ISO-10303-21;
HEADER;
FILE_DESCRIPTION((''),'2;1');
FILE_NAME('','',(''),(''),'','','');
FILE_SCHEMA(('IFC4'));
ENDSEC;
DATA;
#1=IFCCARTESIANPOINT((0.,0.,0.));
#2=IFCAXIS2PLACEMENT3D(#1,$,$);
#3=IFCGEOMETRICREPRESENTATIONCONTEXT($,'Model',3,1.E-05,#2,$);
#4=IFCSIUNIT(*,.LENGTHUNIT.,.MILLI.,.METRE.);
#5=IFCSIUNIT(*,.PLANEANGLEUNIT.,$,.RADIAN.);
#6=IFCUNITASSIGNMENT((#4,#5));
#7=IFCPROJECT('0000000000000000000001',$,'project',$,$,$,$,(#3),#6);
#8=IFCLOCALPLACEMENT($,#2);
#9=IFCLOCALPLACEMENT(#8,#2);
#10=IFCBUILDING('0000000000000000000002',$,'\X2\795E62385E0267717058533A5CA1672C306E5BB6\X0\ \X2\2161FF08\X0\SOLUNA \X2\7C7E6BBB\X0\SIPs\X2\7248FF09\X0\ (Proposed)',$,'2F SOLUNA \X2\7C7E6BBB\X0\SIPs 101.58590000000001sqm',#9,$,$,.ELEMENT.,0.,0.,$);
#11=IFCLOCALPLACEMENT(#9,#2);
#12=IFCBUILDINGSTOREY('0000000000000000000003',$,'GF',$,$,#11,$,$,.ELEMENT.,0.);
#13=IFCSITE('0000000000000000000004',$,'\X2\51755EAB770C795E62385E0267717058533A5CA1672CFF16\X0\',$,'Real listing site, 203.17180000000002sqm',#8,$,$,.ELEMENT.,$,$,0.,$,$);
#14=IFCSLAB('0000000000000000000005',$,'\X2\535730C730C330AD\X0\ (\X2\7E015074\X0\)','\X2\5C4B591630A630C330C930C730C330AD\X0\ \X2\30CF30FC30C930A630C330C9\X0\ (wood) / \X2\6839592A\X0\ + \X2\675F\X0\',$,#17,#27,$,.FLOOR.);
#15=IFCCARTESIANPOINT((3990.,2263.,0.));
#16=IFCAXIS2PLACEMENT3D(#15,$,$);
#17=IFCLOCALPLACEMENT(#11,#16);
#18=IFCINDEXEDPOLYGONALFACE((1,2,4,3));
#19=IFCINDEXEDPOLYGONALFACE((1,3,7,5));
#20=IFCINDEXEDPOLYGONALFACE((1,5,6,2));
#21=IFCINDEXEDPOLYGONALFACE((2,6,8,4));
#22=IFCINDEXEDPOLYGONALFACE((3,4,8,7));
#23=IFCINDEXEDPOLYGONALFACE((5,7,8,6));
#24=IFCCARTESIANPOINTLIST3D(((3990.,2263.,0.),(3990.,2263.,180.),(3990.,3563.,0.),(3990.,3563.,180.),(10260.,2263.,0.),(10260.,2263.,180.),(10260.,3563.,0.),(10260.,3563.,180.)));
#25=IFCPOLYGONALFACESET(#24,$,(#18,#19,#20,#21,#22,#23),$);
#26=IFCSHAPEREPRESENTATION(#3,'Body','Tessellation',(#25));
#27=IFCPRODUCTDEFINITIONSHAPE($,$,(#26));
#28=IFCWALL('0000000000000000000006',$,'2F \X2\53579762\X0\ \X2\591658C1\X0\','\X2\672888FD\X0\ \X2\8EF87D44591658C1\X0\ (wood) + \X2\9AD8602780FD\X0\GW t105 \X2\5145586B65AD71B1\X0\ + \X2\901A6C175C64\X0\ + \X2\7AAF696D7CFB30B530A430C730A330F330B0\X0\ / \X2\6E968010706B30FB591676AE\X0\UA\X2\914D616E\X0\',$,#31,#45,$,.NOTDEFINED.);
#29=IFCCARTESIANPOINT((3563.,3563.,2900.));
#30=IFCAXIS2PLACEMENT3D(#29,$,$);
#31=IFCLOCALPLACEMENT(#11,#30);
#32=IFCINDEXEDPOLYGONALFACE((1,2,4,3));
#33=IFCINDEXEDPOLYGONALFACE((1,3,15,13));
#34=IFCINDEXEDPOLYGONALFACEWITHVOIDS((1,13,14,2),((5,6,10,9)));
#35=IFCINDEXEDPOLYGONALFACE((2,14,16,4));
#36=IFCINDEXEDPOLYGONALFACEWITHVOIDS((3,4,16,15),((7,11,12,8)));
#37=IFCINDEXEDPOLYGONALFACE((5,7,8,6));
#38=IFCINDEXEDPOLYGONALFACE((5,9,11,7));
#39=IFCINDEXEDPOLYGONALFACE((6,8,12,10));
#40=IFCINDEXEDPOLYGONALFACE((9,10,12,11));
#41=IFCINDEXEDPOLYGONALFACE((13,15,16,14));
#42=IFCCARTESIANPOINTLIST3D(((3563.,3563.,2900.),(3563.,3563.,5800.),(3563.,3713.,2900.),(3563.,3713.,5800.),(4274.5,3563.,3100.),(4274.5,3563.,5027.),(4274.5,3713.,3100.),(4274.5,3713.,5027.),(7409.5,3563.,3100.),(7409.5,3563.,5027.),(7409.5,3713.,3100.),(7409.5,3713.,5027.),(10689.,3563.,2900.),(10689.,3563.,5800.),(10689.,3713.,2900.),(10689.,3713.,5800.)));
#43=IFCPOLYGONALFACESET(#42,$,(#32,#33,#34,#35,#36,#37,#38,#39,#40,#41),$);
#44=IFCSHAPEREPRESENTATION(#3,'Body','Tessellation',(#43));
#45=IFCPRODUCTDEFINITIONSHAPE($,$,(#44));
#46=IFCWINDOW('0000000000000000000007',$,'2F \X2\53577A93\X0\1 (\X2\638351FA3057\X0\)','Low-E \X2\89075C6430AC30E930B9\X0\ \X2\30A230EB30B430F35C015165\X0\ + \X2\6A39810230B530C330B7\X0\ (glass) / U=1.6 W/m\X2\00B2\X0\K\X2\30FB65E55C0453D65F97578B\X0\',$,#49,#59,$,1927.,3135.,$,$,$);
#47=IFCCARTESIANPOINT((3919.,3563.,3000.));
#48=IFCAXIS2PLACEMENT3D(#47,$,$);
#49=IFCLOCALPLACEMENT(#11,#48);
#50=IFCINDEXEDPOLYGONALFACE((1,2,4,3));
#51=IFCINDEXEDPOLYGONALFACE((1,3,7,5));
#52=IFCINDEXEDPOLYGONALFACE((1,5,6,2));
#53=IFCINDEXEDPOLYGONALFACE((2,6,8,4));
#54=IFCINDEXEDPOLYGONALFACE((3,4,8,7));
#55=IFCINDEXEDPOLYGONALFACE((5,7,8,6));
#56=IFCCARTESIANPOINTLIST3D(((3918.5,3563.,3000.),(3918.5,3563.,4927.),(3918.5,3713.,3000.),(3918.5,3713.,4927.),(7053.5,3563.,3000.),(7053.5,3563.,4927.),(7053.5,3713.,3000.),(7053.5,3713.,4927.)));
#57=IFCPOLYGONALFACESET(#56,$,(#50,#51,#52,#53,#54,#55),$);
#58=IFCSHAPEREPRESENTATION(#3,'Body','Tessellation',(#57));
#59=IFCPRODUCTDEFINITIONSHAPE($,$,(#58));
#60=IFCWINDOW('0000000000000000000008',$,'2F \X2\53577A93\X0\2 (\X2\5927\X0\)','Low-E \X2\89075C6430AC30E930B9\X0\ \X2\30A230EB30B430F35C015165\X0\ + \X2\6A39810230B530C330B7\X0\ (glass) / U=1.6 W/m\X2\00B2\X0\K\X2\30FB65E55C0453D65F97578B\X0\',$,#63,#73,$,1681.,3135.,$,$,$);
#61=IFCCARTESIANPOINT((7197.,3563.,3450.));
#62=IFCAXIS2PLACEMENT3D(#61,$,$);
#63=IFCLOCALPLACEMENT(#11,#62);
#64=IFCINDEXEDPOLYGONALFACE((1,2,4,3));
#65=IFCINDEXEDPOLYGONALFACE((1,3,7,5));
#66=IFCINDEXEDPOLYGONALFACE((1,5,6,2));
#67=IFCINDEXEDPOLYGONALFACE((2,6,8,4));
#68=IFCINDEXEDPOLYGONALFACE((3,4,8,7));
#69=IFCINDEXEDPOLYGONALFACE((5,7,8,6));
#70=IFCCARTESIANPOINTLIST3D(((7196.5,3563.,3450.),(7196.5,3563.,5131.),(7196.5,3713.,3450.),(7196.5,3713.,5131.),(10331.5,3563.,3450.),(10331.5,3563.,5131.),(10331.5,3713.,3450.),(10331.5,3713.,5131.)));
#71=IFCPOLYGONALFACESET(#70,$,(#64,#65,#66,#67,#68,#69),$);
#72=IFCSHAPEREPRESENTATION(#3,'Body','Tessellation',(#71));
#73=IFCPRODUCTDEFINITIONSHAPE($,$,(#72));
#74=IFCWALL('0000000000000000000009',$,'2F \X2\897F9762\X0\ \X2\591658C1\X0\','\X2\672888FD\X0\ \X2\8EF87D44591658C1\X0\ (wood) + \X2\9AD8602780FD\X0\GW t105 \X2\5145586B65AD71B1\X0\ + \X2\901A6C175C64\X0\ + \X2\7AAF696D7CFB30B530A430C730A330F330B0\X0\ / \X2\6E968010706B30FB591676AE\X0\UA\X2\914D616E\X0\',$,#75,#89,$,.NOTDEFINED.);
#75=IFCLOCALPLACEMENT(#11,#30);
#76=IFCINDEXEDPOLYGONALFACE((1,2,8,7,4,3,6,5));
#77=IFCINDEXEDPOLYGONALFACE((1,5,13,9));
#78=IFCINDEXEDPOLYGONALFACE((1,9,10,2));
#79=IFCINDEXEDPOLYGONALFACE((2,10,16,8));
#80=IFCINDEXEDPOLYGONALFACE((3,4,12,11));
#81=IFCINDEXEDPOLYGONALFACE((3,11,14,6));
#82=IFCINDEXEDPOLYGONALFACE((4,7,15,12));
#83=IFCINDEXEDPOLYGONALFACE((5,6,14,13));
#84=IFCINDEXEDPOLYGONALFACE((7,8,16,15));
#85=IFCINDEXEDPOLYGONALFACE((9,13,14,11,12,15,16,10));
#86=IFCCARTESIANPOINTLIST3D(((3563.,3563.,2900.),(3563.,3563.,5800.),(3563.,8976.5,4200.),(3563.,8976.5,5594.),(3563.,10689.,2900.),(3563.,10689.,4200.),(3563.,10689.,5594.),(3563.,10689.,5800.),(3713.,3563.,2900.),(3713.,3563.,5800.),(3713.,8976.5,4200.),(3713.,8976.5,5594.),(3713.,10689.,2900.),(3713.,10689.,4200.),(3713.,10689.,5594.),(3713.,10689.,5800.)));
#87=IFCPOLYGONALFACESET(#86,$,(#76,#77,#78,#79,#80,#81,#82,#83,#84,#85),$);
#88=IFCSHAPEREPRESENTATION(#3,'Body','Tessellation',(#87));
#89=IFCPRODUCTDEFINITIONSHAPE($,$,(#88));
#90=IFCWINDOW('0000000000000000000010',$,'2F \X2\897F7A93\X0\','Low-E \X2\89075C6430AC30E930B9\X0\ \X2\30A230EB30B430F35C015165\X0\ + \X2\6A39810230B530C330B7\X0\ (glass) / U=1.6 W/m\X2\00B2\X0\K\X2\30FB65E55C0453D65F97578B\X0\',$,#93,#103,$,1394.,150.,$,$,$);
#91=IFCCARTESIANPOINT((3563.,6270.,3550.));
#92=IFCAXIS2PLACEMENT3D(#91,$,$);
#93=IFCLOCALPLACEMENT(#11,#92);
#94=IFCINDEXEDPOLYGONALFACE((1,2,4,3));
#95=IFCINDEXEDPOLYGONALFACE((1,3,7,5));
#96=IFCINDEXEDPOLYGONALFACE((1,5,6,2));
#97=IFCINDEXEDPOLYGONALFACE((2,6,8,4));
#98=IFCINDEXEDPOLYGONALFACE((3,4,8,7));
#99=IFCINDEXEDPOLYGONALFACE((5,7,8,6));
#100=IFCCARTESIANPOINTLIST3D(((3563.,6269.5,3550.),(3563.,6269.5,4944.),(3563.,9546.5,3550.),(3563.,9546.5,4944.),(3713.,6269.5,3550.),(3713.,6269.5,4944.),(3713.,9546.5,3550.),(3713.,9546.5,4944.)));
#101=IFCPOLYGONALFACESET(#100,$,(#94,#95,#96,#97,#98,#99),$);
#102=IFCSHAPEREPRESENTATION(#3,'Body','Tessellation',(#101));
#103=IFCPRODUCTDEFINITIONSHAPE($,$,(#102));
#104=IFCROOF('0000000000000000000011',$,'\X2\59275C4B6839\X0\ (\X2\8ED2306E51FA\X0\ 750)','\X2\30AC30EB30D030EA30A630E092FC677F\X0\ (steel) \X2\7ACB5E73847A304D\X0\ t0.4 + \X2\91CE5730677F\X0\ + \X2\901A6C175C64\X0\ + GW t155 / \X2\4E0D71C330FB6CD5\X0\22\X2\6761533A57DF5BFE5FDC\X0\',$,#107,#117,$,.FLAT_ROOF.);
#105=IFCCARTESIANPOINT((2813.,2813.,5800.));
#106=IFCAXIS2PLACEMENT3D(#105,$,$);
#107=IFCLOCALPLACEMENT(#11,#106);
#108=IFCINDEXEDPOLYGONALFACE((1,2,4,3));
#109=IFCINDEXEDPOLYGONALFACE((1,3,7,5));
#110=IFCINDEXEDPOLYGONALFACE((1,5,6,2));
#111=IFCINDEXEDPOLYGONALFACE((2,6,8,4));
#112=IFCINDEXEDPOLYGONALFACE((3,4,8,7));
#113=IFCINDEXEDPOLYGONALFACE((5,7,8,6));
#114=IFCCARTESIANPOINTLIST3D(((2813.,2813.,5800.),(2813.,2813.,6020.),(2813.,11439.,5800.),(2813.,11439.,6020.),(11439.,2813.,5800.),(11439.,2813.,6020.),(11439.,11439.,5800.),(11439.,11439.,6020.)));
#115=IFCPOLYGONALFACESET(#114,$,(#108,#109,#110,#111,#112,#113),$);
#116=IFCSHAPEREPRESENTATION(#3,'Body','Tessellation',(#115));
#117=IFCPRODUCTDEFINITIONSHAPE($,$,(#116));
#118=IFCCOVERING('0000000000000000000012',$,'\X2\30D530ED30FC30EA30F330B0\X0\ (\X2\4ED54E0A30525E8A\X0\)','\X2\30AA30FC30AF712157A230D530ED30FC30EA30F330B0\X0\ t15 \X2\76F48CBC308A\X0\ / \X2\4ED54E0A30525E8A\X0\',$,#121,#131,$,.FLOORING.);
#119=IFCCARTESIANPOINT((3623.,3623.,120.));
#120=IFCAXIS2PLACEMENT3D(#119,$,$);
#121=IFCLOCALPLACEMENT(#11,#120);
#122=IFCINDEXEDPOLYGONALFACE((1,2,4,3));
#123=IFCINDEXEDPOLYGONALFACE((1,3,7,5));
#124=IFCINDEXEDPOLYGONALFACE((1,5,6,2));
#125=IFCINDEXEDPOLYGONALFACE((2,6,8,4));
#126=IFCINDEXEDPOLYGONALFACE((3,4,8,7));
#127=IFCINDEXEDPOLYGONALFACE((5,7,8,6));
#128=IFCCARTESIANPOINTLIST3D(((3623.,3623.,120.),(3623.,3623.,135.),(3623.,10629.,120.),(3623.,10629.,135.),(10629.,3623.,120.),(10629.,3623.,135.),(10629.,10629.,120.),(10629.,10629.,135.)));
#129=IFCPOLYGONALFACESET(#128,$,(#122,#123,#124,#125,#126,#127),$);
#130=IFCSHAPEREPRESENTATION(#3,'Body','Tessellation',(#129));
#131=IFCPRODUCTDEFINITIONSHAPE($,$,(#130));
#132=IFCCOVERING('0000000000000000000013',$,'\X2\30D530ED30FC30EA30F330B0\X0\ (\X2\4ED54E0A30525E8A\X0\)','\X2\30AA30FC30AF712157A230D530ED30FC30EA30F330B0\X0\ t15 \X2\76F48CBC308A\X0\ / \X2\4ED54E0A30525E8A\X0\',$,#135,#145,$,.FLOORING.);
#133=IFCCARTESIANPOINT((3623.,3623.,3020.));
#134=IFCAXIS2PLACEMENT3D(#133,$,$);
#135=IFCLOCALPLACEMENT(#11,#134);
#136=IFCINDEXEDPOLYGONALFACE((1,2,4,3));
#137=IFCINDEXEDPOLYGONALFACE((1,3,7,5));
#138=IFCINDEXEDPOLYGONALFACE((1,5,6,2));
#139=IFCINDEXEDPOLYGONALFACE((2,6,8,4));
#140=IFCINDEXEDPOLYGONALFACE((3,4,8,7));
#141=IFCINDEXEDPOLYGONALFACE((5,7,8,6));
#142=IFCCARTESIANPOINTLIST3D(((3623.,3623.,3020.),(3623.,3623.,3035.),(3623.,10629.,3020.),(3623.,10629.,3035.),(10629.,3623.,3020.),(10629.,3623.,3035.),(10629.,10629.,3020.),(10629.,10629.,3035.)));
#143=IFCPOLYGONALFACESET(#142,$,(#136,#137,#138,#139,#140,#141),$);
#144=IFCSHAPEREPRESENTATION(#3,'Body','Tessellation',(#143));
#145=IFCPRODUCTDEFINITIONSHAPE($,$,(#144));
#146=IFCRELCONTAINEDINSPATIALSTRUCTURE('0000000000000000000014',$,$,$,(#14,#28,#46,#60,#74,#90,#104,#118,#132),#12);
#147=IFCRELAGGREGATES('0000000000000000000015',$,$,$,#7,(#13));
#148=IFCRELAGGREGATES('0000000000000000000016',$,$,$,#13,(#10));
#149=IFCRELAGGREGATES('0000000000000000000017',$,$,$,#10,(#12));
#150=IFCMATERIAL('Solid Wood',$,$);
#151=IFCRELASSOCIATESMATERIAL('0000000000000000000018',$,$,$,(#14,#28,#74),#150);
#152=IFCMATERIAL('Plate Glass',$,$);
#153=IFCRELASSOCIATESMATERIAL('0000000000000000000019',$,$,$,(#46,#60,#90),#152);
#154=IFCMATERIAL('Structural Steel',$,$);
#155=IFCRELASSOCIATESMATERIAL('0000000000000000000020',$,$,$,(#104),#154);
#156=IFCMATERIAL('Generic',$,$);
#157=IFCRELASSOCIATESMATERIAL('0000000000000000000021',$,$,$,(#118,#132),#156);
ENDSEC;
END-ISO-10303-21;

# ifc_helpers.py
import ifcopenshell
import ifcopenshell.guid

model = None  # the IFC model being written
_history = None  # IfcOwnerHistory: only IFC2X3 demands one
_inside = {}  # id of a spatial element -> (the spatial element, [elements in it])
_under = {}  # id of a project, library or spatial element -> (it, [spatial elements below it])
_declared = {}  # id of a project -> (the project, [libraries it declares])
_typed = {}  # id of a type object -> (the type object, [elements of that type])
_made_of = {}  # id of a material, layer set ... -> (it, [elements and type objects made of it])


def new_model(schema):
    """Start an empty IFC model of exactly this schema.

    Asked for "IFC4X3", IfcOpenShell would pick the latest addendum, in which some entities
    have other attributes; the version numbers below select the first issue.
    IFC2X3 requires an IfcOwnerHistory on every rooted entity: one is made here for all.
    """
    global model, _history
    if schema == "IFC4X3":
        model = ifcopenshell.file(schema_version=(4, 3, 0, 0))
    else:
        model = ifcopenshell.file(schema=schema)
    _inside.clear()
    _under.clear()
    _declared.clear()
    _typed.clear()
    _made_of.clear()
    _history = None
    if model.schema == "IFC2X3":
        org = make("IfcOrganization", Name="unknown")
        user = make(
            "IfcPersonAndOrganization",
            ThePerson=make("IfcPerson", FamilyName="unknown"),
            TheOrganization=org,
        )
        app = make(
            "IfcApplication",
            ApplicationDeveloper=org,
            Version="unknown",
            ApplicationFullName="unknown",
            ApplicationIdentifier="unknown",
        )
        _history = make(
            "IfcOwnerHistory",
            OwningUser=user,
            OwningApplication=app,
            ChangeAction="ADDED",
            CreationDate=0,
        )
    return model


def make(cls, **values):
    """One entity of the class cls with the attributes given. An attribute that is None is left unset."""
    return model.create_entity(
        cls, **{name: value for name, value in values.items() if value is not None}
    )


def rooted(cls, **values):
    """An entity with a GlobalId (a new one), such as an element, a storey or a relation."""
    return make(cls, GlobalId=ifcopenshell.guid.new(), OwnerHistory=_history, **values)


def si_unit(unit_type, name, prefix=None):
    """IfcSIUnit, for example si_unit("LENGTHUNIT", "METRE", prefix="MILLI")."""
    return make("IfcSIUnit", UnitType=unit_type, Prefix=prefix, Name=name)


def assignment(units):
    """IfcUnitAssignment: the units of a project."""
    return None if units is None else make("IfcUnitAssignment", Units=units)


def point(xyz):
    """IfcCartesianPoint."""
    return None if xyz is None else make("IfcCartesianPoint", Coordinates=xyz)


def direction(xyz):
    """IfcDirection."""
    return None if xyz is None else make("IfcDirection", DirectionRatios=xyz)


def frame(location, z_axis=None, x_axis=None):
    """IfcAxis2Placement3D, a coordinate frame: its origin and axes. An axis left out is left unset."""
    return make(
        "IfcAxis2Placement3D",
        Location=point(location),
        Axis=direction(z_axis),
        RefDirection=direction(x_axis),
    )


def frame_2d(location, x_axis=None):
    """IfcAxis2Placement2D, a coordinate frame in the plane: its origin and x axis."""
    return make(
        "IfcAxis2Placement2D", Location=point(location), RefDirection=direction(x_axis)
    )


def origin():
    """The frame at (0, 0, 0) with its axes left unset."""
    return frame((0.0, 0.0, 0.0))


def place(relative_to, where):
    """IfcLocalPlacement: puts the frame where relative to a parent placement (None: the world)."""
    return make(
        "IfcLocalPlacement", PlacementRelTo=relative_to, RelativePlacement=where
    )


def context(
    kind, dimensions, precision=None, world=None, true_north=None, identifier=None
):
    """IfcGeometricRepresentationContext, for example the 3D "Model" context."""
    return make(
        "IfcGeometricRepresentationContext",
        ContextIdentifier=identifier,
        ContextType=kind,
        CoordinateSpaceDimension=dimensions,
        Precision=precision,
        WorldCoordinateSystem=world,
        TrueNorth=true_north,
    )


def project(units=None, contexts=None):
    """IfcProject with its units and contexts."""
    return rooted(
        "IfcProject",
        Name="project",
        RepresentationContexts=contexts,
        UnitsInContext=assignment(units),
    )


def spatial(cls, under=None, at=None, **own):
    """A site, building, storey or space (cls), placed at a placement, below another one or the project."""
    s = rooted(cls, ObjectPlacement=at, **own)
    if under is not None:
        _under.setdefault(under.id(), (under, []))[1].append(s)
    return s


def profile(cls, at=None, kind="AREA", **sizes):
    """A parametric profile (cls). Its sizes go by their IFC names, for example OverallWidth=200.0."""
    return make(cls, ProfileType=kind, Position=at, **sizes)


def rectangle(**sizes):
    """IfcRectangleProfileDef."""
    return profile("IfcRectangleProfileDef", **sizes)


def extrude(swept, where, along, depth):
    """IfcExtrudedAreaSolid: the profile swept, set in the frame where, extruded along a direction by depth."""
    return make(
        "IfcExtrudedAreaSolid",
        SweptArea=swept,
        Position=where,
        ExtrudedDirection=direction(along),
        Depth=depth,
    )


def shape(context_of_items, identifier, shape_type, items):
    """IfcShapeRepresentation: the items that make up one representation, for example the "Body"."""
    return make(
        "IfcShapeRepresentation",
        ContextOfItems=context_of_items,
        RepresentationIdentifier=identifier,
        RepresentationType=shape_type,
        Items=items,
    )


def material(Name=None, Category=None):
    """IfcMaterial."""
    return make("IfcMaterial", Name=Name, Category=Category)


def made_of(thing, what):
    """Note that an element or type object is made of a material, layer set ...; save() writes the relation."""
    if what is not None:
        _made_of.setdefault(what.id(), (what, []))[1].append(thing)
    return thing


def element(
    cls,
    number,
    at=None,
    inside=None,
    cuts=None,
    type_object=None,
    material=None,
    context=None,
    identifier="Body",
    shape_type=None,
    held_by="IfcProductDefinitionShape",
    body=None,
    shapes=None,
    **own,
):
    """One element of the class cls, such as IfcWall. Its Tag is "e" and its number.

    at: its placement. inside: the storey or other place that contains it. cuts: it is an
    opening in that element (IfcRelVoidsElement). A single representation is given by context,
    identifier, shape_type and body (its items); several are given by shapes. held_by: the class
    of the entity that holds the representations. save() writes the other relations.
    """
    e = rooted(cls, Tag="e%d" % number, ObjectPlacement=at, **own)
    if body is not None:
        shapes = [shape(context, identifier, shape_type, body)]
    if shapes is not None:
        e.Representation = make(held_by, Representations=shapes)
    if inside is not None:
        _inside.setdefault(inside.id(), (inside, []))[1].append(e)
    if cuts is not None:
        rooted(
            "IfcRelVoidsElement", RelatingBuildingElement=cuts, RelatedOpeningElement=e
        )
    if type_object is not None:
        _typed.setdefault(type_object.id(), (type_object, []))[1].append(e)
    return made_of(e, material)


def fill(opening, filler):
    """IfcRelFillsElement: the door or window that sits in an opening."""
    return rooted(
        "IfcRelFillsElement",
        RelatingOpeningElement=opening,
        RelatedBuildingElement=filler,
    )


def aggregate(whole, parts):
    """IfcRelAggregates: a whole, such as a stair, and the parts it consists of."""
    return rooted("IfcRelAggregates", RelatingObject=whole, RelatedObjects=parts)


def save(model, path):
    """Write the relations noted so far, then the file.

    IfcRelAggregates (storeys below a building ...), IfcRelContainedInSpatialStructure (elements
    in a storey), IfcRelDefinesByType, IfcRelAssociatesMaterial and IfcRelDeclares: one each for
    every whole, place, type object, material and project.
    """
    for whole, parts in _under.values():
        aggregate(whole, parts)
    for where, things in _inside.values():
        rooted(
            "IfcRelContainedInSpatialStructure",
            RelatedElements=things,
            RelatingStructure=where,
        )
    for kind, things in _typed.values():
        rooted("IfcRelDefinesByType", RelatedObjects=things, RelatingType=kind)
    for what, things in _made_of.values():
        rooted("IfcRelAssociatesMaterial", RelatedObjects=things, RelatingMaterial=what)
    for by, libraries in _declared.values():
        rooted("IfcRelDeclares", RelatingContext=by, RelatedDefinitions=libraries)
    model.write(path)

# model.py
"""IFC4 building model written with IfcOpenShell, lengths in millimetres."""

from ifc_helpers import new_model, si_unit, frame, frame_2d, origin, place, context, project, spatial, rectangle, extrude, material, element, fill, save


model = new_model("IFC4")

# Units and contexts
model_context = context("Model", 3, precision=1e-05, world=origin())
ifc_project = project(units=[si_unit("LENGTHUNIT", "METRE", prefix="MILLI"), si_unit("PLANEANGLEUNIT", "RADIAN")], contexts=[model_context])

# Site, building, storey
site_placement = place(None, origin())
site = spatial("IfcSite", under=ifc_project, at=site_placement, Name="兵庫県神戸市東灘区岡本６", ObjectType="Real listing site, 203.17180000000002sqm", CompositionType="ELEMENT", RefElevation=0.0)
building_placement = place(site_placement, origin())
building = spatial("IfcBuilding", under=site, at=building_placement, Name="神戸市東灘区岡本の家 Ⅱ（SOLUNA 籾殻SIPs版） (Proposed)", ObjectType="2F SOLUNA 籾殻SIPs 101.58590000000001sqm", CompositionType="ELEMENT", ElevationOfRefHeight=0.0, ElevationOfTerrain=0.0)
storey_placement = place(building_placement, origin())
storey = spatial("IfcBuildingStorey", under=building, at=storey_placement, Name="GF", CompositionType="ELEMENT", Elevation=0.0)

# Slab
ifc_material_1 = material(Name="Solid Wood")
slab_1_placement = place(storey_placement, frame((3990.0, 2263.0, 0.0)))
element("IfcSlab", 1, at=slab_1_placement, inside=storey, material=ifc_material_1, Name="南デッキ (縁側)", Description="屋外ウッドデッキ ハードウッド (wood) / 根太 + 束", PredefinedType="FLOOR", context=model_context, shape_type="SweptSolid", body=[
    extrude(rectangle(XDim=6270.0, YDim=1300.0, at=frame_2d((3135.0, 650.0))), frame((3990.0, 2263.0, 0.0)), (0.0, 0.0, 1.0), 180.0),
])

# Shared definitions
ifc_material_2 = material(Name="Plate Glass")

# Wall, openings, windows
wall_1_placement = place(storey_placement, frame((3563.0, 3563.0, 2900.0)))
wall_1 = element("IfcWall", 2, at=wall_1_placement, inside=storey, material=ifc_material_1, Name="2F 南面 外壁", Description="木製 軸組外壁 (wood) + 高性能GW t105 充填断熱 + 通気層 + 窯業系サイディング / 準耐火・外皮UA配慮", PredefinedType="NOTDEFINED", context=model_context, shape_type="SweptSolid", body=[
    extrude(rectangle(XDim=7126.0, YDim=150.0, at=frame_2d((3563.0, 75.0))), frame((3563.0, 3563.0, 2900.0)), (0.0, 0.0, 1.0), 2900.0),
])
opening_1_placement = place(storey_placement, frame((3919.0, 3563.0, 3000.0)))
opening_1 = element("IfcOpeningElement", 3, at=opening_1_placement, cuts=wall_1, PredefinedType="NOTDEFINED", context=model_context, shape_type="SweptSolid", body=[
    extrude(rectangle(XDim=3135.0, YDim=150.0, at=frame_2d((1567.0, 75.0))), frame((3919.0, 3563.0, 3000.0)), (0.0, 0.0, 1.0), 1927.0),
])
opening_2_placement = place(storey_placement, frame((7197.0, 3563.0, 3450.0)))
opening_2 = element("IfcOpeningElement", 4, at=opening_2_placement, cuts=wall_1, PredefinedType="NOTDEFINED", context=model_context, shape_type="SweptSolid", body=[
    extrude(rectangle(XDim=3135.0, YDim=150.0, at=frame_2d((1567.0, 75.0))), frame((7197.0, 3563.0, 3450.0)), (0.0, 0.0, 1.0), 1681.0),
])
window_1_placement = place(storey_placement, frame((3919.0, 3563.0, 3000.0)))
window_1 = element("IfcWindow", 5, at=window_1_placement, inside=storey, material=ifc_material_2, Name="2F 南窓1 (掃出し)", Description="Low-E 複層ガラス アルゴン封入 + 樹脂サッシ (glass) / U=1.6 W/m²K・日射取得型", OverallHeight=1927.0, OverallWidth=3135.0, context=model_context, shape_type="SweptSolid", body=[
    extrude(rectangle(XDim=3135.0, YDim=150.0, at=frame_2d((1567.0, 75.0))), frame((3919.0, 3563.0, 3000.0)), (0.0, 0.0, 1.0), 1927.0),
])
fill(opening_1, window_1)
window_2_placement = place(storey_placement, frame((7197.0, 3563.0, 3450.0)))
window_2 = element("IfcWindow", 6, at=window_2_placement, inside=storey, material=ifc_material_2, Name="2F 南窓2 (大)", Description="Low-E 複層ガラス アルゴン封入 + 樹脂サッシ (glass) / U=1.6 W/m²K・日射取得型", OverallHeight=1681.0, OverallWidth=3135.0, context=model_context, shape_type="SweptSolid", body=[
    extrude(rectangle(XDim=3135.0, YDim=150.0, at=frame_2d((1567.0, 75.0))), frame((7197.0, 3563.0, 3450.0)), (0.0, 0.0, 1.0), 1681.0),
])
fill(opening_2, window_2)

# Wall, opening, window
wall_2_placement = place(storey_placement, frame((3563.0, 3563.0, 2900.0)))
wall_2 = element("IfcWall", 7, at=wall_2_placement, inside=storey, material=ifc_material_1, Name="2F 西面 外壁", Description="木製 軸組外壁 (wood) + 高性能GW t105 充填断熱 + 通気層 + 窯業系サイディング / 準耐火・外皮UA配慮", PredefinedType="NOTDEFINED", context=model_context, shape_type="SweptSolid", body=[
    extrude(rectangle(XDim=150.0, YDim=7126.0, at=frame_2d((75.0, 3563.0))), frame((3563.0, 3563.0, 2900.0)), (0.0, 0.0, 1.0), 2900.0),
])
opening_3_placement = place(storey_placement, frame((3563.0, 6270.0, 3550.0)))
opening_3 = element("IfcOpeningElement", 8, at=opening_3_placement, cuts=wall_2, PredefinedType="NOTDEFINED", context=model_context, shape_type="SweptSolid", body=[
    extrude(rectangle(XDim=150.0, YDim=3277.0, at=frame_2d((75.0, 1638.0))), frame((3563.0, 6270.0, 3550.0)), (0.0, 0.0, 1.0), 1394.0),
])
window_3_placement = place(storey_placement, frame((3563.0, 6270.0, 3550.0)))
window_3 = element("IfcWindow", 9, at=window_3_placement, inside=storey, material=ifc_material_2, Name="2F 西窓", Description="Low-E 複層ガラス アルゴン封入 + 樹脂サッシ (glass) / U=1.6 W/m²K・日射取得型", OverallHeight=1394.0, OverallWidth=150.0, context=model_context, shape_type="SweptSolid", body=[
    extrude(rectangle(XDim=150.0, YDim=3277.0, at=frame_2d((75.0, 1638.0))), frame((3563.0, 6270.0, 3550.0)), (0.0, 0.0, 1.0), 1394.0),
])
fill(opening_3, window_3)

# Roof
ifc_material_3 = material(Name="Structural Steel")
roof_placement = place(storey_placement, frame((2813.0, 2813.0, 5800.0)))
element("IfcRoof", 10, at=roof_placement, inside=storey, material=ifc_material_3, Name="大屋根 (軒の出 750)", Description="ガルバリウム鋼板 (steel) 立平葺き t0.4 + 野地板 + 通気層 + GW t155 / 不燃・法22条区域対応", PredefinedType="FLAT_ROOF", context=model_context, shape_type="SweptSolid", body=[
    extrude(rectangle(XDim=8626.0, YDim=8626.0, at=frame_2d((4313.0, 4313.0))), frame((2813.0, 2813.0, 5800.0)), (0.0, 0.0, 1.0), 220.0),
])

# Coverings
ifc_material_4 = material(Name="Generic")
covering_1_placement = place(storey_placement, frame((3623.0, 3623.0, 120.0)))
element("IfcCovering", 11, at=covering_1_placement, inside=storey, material=ifc_material_4, Name="フローリング (仕上げ床)", Description="オーク無垢フローリング t15 直貼り / 仕上げ床", PredefinedType="FLOORING", context=model_context, shape_type="SweptSolid", body=[
    extrude(rectangle(XDim=7006.0, YDim=7006.0, at=frame_2d((3503.0, 3503.0))), frame((3623.0, 3623.0, 120.0)), (0.0, 0.0, 1.0), 15.0),
])
covering_2_placement = place(storey_placement, frame((3623.0, 3623.0, 3020.0)))
element("IfcCovering", 12, at=covering_2_placement, inside=storey, material=ifc_material_4, Name="フローリング (仕上げ床)", Description="オーク無垢フローリング t15 直貼り / 仕上げ床", PredefinedType="FLOORING", context=model_context, shape_type="SweptSolid", body=[
    extrude(rectangle(XDim=7006.0, YDim=7006.0, at=frame_2d((3503.0, 3503.0))), frame((3623.0, 3623.0, 3020.0)), (0.0, 0.0, 1.0), 15.0),
])

save(model, "model.ifc")
